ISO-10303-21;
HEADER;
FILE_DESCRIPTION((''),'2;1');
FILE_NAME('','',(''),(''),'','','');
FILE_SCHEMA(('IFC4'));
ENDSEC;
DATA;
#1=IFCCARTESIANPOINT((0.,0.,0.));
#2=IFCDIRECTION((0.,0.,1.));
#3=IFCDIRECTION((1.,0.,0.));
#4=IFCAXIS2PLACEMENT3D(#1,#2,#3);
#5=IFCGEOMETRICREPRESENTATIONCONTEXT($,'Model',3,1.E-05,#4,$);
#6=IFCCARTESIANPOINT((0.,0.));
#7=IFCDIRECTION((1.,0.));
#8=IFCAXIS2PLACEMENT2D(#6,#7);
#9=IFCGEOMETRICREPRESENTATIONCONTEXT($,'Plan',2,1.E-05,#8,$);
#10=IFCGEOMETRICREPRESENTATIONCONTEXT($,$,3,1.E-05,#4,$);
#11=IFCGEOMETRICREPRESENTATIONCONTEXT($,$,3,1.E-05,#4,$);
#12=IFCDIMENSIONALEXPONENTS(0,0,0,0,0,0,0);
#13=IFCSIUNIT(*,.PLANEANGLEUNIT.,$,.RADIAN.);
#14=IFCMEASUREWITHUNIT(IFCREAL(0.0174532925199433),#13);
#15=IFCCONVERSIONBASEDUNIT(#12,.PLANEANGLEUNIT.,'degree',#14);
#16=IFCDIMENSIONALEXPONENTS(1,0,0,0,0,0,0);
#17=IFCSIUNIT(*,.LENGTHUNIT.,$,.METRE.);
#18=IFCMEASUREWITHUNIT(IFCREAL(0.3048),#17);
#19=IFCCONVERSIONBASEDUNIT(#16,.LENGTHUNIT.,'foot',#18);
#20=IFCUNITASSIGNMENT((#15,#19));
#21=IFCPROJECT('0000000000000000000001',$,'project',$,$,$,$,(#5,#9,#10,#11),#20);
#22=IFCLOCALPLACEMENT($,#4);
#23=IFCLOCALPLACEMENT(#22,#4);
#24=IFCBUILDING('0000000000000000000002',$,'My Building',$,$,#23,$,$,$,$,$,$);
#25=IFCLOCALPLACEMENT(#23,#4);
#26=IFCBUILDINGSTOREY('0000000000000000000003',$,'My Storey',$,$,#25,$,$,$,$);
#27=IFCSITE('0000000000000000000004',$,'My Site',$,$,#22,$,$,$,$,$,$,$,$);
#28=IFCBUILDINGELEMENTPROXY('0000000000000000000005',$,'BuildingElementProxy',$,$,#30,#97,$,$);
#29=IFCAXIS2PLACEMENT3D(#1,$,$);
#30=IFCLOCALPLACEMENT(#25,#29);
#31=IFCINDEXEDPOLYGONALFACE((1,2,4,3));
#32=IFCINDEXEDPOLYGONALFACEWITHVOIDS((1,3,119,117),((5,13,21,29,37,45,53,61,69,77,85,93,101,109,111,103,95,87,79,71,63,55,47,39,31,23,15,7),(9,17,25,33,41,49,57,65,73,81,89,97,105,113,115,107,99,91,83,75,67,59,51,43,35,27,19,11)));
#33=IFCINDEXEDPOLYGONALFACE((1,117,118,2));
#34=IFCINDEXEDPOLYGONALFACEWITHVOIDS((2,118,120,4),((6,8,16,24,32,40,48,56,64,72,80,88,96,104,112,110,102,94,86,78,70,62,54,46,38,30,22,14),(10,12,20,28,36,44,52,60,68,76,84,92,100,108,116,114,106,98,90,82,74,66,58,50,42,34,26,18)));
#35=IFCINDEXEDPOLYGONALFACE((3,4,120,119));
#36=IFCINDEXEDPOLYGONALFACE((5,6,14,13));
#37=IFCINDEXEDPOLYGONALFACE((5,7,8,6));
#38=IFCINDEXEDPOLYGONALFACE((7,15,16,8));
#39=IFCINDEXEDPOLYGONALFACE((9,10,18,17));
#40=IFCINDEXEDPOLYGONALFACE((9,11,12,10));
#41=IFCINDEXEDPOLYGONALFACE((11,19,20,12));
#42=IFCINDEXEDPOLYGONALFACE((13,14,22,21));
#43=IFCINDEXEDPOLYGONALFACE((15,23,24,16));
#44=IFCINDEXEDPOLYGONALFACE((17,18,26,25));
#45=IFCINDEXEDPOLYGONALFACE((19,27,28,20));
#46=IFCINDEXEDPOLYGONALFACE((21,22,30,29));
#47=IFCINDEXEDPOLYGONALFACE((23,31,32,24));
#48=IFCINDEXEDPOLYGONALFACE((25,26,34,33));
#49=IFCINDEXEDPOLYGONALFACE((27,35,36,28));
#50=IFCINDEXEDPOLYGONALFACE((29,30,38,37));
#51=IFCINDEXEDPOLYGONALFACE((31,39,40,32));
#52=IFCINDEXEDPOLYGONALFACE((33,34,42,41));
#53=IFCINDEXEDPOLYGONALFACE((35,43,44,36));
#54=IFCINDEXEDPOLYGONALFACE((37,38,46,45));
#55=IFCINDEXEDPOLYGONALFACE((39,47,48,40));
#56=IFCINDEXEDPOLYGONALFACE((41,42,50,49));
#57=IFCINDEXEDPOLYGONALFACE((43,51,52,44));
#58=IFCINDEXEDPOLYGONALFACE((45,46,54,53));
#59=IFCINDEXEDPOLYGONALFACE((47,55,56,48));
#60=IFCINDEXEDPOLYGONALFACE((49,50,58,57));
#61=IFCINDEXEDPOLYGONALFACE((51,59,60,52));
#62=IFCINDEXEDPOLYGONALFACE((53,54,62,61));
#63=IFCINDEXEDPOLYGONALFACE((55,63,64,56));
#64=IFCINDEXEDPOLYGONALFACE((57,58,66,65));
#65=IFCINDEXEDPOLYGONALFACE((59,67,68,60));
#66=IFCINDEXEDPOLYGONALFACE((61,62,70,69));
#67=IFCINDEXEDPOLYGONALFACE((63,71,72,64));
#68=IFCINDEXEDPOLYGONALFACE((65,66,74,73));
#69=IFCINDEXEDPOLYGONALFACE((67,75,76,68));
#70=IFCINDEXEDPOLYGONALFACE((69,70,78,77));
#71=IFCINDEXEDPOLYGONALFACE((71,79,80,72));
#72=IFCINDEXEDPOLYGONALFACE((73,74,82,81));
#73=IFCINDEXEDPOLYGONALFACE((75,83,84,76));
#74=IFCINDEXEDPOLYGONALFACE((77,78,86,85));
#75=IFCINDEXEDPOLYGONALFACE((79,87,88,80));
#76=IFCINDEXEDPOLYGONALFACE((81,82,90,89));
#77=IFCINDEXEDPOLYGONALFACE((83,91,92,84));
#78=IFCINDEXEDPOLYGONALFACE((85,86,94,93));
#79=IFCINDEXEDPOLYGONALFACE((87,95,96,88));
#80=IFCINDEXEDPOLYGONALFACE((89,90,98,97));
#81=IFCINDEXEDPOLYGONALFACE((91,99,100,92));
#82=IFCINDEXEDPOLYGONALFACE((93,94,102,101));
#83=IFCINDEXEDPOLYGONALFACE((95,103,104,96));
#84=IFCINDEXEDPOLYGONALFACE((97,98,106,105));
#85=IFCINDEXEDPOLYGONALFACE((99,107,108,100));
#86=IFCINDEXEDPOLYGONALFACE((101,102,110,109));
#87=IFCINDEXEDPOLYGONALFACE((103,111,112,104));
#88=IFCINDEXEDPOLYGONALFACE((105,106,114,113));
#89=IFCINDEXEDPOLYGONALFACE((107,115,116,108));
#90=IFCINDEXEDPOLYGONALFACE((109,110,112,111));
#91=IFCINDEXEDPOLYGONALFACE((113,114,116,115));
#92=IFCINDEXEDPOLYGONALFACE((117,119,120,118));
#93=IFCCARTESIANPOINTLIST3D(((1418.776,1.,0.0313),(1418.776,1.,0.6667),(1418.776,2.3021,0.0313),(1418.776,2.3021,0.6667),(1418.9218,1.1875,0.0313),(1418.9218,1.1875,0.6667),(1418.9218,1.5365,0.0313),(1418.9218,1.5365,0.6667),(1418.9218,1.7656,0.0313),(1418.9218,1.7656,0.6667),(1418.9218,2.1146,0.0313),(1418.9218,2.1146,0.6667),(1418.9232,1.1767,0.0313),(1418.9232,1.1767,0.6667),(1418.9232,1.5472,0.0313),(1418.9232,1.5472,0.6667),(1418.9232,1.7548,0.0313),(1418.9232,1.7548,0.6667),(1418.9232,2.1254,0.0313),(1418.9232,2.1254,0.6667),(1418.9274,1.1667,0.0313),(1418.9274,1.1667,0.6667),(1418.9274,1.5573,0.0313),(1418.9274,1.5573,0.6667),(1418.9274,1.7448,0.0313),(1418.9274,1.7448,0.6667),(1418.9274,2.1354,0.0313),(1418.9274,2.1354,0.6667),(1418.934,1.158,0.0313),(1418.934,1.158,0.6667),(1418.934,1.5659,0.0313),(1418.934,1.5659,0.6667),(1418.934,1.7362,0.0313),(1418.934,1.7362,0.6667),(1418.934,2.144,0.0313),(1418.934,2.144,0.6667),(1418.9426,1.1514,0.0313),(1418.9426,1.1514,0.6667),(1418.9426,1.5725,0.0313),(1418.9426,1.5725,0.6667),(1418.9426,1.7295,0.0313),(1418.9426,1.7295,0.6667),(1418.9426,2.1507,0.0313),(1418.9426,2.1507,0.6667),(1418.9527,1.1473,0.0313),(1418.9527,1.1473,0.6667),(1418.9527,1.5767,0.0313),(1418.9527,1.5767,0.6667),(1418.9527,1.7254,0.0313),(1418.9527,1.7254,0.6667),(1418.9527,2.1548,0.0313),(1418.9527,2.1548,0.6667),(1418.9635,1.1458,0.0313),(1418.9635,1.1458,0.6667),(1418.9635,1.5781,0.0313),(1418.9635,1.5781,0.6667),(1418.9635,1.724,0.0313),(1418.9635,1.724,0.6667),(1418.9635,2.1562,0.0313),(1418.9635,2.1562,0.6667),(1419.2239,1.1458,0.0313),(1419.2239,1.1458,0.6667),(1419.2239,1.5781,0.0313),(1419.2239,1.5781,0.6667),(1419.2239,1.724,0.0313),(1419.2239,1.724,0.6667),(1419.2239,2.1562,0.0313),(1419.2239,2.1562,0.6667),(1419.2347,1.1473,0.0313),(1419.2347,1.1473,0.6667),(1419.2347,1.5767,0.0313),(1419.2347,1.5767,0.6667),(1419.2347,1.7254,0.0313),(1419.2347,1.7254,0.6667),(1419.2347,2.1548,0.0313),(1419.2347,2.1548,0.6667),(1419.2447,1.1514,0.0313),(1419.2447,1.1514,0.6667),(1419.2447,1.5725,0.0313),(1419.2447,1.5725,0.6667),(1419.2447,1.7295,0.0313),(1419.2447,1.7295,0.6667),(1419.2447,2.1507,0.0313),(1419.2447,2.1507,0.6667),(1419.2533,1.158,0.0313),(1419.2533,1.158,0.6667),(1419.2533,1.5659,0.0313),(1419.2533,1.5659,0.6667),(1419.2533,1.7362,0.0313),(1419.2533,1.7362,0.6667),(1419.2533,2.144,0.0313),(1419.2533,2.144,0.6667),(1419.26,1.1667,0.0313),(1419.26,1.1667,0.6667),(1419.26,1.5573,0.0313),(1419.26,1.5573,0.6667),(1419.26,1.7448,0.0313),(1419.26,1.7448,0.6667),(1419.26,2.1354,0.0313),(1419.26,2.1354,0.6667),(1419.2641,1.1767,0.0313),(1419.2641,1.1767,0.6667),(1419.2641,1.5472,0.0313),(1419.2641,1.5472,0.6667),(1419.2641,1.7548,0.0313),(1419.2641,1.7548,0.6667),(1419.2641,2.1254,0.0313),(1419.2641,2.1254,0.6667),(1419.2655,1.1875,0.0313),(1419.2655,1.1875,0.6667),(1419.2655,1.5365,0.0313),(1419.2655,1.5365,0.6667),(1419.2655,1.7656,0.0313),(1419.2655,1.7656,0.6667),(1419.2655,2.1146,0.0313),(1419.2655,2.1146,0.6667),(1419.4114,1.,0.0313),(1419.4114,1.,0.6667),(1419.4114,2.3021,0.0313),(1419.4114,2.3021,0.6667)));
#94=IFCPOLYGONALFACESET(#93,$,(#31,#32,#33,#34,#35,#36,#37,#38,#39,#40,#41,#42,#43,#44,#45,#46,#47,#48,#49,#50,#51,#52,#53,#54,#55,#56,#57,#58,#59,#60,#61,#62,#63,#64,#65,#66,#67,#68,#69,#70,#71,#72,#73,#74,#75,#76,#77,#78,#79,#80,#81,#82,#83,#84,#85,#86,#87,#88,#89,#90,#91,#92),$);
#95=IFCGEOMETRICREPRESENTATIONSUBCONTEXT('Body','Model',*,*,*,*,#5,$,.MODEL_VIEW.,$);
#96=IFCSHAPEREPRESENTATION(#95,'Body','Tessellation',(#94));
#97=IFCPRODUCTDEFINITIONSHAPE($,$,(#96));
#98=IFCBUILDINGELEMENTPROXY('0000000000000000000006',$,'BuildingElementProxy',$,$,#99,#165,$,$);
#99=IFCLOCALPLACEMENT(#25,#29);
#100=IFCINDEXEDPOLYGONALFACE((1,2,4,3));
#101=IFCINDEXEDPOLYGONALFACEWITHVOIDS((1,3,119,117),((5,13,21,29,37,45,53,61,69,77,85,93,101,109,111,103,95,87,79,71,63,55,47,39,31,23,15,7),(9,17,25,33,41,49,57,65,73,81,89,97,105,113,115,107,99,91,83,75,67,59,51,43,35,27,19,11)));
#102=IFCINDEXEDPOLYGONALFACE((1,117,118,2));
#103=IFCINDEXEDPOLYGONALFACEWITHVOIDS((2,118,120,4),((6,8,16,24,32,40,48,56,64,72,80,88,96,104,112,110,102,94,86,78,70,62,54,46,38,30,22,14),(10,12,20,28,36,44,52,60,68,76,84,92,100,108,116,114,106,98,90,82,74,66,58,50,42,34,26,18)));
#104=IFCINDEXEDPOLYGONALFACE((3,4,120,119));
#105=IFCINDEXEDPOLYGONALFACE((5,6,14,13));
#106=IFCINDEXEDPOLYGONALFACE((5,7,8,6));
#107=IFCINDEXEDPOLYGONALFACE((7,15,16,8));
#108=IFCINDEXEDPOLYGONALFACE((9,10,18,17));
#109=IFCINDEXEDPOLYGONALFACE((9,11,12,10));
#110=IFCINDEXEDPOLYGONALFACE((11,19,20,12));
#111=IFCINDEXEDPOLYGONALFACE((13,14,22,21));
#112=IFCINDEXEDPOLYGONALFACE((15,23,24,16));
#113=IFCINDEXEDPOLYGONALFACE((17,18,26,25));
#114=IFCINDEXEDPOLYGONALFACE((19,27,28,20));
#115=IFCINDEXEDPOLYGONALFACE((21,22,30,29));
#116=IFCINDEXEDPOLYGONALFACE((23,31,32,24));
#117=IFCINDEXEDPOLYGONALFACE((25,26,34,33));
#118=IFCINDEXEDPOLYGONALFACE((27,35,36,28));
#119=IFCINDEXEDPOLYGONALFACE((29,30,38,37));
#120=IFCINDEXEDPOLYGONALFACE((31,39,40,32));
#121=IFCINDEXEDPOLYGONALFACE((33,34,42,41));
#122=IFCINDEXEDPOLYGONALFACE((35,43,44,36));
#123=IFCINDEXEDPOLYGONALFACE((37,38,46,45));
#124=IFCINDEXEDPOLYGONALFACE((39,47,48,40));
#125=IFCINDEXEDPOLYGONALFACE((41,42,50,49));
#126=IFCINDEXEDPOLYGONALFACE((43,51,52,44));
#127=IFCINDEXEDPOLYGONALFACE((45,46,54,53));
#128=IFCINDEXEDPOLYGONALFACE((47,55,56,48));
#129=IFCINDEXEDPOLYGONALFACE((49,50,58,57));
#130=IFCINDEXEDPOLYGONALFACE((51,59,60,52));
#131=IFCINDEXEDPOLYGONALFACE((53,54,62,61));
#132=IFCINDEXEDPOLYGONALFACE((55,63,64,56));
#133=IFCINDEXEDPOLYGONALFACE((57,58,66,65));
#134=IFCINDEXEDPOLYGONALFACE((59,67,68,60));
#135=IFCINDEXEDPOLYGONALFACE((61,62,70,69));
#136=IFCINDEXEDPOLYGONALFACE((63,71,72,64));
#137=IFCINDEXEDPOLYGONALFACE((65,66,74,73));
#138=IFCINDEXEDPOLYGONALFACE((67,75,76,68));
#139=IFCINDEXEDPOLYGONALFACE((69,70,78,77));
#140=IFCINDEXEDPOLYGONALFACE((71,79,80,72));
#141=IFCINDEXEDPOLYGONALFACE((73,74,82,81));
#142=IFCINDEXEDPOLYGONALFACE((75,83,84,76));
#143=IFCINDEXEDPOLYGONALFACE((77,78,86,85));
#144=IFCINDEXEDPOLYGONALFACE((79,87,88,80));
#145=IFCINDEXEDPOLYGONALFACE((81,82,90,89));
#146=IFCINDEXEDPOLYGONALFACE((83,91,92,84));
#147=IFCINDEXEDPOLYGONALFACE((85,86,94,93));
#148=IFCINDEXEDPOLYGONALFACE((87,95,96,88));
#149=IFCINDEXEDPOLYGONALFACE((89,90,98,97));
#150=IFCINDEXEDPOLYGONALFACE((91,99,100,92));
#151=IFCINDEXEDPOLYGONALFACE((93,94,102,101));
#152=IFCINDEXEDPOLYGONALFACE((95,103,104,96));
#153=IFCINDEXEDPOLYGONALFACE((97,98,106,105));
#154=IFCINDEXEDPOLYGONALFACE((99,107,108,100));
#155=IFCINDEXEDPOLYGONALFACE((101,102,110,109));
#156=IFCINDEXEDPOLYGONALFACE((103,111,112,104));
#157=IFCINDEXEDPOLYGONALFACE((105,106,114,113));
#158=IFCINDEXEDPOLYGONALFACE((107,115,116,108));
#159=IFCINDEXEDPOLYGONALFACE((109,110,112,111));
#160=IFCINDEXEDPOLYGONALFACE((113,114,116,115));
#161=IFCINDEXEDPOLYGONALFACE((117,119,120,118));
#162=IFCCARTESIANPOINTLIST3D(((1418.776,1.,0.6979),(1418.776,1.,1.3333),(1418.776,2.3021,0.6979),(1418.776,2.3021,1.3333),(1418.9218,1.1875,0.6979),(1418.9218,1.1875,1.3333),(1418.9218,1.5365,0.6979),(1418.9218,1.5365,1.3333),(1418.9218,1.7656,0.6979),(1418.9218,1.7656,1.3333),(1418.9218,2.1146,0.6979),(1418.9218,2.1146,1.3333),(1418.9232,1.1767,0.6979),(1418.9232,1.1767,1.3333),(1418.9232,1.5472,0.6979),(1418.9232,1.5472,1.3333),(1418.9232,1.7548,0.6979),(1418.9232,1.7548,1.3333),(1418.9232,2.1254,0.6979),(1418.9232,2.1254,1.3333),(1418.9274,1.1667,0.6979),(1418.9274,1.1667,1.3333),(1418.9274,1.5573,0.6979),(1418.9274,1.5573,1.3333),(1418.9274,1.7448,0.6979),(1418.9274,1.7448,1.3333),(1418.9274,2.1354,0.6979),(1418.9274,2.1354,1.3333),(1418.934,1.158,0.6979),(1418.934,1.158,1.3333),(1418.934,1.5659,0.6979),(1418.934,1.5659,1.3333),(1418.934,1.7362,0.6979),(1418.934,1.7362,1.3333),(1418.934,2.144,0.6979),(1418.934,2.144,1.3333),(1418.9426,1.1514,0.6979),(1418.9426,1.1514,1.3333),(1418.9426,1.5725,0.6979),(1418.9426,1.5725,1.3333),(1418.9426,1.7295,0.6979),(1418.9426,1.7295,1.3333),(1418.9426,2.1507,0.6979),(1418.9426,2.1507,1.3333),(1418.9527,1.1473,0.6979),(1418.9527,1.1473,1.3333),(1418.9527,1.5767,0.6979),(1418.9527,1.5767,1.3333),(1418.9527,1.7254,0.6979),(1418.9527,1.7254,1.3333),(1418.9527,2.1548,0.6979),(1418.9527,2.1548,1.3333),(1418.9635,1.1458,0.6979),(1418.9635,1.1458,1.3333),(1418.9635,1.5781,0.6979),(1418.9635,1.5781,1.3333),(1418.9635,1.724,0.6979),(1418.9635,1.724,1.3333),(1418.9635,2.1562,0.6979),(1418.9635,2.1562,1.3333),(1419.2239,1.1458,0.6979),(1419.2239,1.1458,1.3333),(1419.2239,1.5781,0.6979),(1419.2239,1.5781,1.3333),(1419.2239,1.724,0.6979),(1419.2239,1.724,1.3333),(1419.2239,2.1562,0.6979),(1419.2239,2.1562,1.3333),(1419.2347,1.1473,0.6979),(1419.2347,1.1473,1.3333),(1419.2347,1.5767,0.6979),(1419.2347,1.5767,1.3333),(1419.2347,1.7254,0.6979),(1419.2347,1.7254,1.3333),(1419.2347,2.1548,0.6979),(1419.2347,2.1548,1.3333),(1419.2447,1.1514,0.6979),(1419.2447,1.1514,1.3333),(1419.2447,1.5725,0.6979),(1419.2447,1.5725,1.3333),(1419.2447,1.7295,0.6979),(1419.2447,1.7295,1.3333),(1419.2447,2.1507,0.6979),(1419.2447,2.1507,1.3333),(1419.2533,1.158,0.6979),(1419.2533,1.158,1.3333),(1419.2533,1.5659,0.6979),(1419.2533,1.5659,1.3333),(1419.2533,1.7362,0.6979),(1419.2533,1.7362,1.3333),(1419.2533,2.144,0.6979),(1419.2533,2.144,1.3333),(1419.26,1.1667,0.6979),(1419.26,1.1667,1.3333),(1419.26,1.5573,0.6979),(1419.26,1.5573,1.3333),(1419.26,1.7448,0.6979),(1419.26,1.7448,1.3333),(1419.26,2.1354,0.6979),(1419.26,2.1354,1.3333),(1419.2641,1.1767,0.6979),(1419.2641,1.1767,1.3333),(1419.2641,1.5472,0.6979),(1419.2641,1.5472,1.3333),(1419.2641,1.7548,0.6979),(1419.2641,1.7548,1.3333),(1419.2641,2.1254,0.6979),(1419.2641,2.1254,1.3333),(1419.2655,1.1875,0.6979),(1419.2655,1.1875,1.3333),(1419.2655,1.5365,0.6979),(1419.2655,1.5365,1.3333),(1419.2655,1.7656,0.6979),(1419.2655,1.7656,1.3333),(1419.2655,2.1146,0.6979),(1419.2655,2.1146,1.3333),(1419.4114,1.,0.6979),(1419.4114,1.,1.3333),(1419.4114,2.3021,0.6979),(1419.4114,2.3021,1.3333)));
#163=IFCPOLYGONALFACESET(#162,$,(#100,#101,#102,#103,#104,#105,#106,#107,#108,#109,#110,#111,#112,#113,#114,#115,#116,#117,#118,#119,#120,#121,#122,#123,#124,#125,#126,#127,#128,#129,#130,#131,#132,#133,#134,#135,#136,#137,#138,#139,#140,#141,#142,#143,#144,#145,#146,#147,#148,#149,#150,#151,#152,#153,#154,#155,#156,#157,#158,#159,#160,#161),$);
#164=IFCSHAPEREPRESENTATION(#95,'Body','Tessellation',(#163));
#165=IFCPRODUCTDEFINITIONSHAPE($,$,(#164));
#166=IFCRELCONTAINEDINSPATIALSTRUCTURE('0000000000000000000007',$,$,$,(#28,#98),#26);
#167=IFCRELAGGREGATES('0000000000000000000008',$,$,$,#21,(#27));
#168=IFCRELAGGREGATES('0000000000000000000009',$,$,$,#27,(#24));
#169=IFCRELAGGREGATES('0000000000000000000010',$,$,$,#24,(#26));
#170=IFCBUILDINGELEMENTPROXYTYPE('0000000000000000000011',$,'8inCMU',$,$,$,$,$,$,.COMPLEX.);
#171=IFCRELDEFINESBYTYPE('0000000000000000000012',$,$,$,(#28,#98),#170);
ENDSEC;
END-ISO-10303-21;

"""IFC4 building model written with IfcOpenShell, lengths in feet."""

from ifc_helpers import new_model, entity, si_unit, converted_unit, frame, origin_with_axes, origin_2d_with_axis, place, context, subcontext, project, spatial, line, indexed_curve, outline, extrude, source, transform, mapped, type_object, type_shapes, element, save


model = new_model("IFC4")

# Units and contexts
model_context_1 = context("Model", 3, precision=1e-05, world=origin_with_axes())
plan_context = context("Plan", 2, precision=1e-05, world=origin_2d_with_axis())
context_of_model_1 = context(None, 3, precision=1e-05, world=origin_with_axes())
context_of_model_2 = context(None, 3, precision=1e-05, world=origin_with_axes())
body_context_1 = subcontext(model_context_1, "Body", "Model", "MODEL_VIEW")
ifc_project = project(units=[converted_unit("PLANEANGLEUNIT", "degree", entity("IfcReal", 0.0174532925199433), si_unit("PLANEANGLEUNIT", "RADIAN"), dimensions=[0, 0, 0, 0, 0, 0, 0]), converted_unit("LENGTHUNIT", "foot", entity("IfcReal", 0.3048), si_unit("LENGTHUNIT", "METRE"), dimensions=[1, 0, 0, 0, 0, 0, 0])], contexts=[model_context_1, plan_context, context_of_model_1, context_of_model_2])

# Site, building, storey
site_placement = place(None, origin_with_axes())
site = spatial("IfcSite", under=ifc_project, at=site_placement, Name="My Site")
building_placement = place(site_placement, origin_with_axes())
building = spatial("IfcBuilding", under=site, at=building_placement, Name="My Building")
storey_placement = place(building_placement, origin_with_axes())
storey = spatial("IfcBuildingStorey", under=building, at=storey_placement, Name="My Storey")

# Building element proxies
building_element_proxy_type_1 = type_object("IfcBuildingElementProxyType", Name="8inCMU", PredefinedType="COMPLEX")
shared_shape_1 = source(origin_with_axes(), body_context_1, "Body", "SweptSolid", [
    extrude(outline(indexed_curve([(-0.3177, -0.651), (0.3177, -0.651), (0.3177, 0.651), (-0.3177, 0.651), (0.1719, -0.1146), (0.1719, -0.4635), (0.1705, -0.4743), (0.1663, -0.4844), (0.1597, -0.493), (0.151, -0.4996), (0.141, -0.5038), (0.1302, -0.5052), (-0.1302, -0.5052), (-0.141, -0.5038), (-0.151, -0.4996), (-0.1597, -0.493), (-0.1663, -0.4844), (-0.1705, -0.4743), (-0.1719, -0.4635), (-0.1719, -0.1146), (-0.1705, -0.1038), (-0.1663, -0.0938), (-0.1597, -0.0851), (-0.151, -0.0785), (-0.141, -0.0743), (-0.1302, -0.0729), (0.1302, -0.0729), (0.141, -0.0743), (0.151, -0.0785), (0.1597, -0.0851), (0.1663, -0.0938), (0.1705, -0.1038), (0.151, 0.0785), (0.141, 0.0743), (0.1302, 0.0729), (-0.1302, 0.0729), (-0.141, 0.0743), (-0.151, 0.0785), (-0.1597, 0.0851), (-0.1663, 0.0937), (-0.1705, 0.1038), (-0.1719, 0.1146), (-0.1719, 0.4635), (-0.1705, 0.4743), (-0.1663, 0.4844), (-0.1597, 0.493), (-0.151, 0.4996), (-0.141, 0.5038), (-0.1302, 0.5052), (0.1302, 0.5052), (0.141, 0.5038), (0.151, 0.4996), (0.1597, 0.493), (0.1663, 0.4844), (0.1705, 0.4743), (0.1719, 0.4635), (0.1719, 0.1146), (0.1705, 0.1038), (0.1663, 0.0937), (0.1597, 0.0851)], segments=[line(4, 3), line(3, 2), line(2, 1), line(1, 4)], self_intersect=False), holes=[indexed_curve([(-0.3177, -0.651), (0.3177, -0.651), (0.3177, 0.651), (-0.3177, 0.651), (0.1719, -0.1146), (0.1719, -0.4635), (0.1705, -0.4743), (0.1663, -0.4844), (0.1597, -0.493), (0.151, -0.4996), (0.141, -0.5038), (0.1302, -0.5052), (-0.1302, -0.5052), (-0.141, -0.5038), (-0.151, -0.4996), (-0.1597, -0.493), (-0.1663, -0.4844), (-0.1705, -0.4743), (-0.1719, -0.4635), (-0.1719, -0.1146), (-0.1705, -0.1038), (-0.1663, -0.0938), (-0.1597, -0.0851), (-0.151, -0.0785), (-0.141, -0.0743), (-0.1302, -0.0729), (0.1302, -0.0729), (0.141, -0.0743), (0.151, -0.0785), (0.1597, -0.0851), (0.1663, -0.0938), (0.1705, -0.1038), (0.151, 0.0785), (0.141, 0.0743), (0.1302, 0.0729), (-0.1302, 0.0729), (-0.141, 0.0743), (-0.151, 0.0785), (-0.1597, 0.0851), (-0.1663, 0.0937), (-0.1705, 0.1038), (-0.1719, 0.1146), (-0.1719, 0.4635), (-0.1705, 0.4743), (-0.1663, 0.4844), (-0.1597, 0.493), (-0.151, 0.4996), (-0.141, 0.5038), (-0.1302, 0.5052), (0.1302, 0.5052), (0.141, 0.5038), (0.151, 0.4996), (0.1597, 0.493), (0.1663, 0.4844), (0.1705, 0.4743), (0.1719, 0.4635), (0.1719, 0.1146), (0.1705, 0.1038), (0.1663, 0.0937), (0.1597, 0.0851)], segments=[line(20, 19), line(19, 18), line(18, 17), line(17, 16), line(16, 15), line(15, 14), line(14, 13), line(13, 12), line(12, 11), line(11, 10), line(10, 9), line(9, 8), line(8, 7), line(7, 6), line(6, 5), line(5, 32), line(32, 31), line(31, 30), line(30, 29), line(29, 28), line(28, 27), line(27, 26), line(26, 25), line(25, 24), line(24, 23), line(23, 22), line(22, 21), line(21, 20)], self_intersect=False), indexed_curve([(-0.3177, -0.651), (0.3177, -0.651), (0.3177, 0.651), (-0.3177, 0.651), (0.1719, -0.1146), (0.1719, -0.4635), (0.1705, -0.4743), (0.1663, -0.4844), (0.1597, -0.493), (0.151, -0.4996), (0.141, -0.5038), (0.1302, -0.5052), (-0.1302, -0.5052), (-0.141, -0.5038), (-0.151, -0.4996), (-0.1597, -0.493), (-0.1663, -0.4844), (-0.1705, -0.4743), (-0.1719, -0.4635), (-0.1719, -0.1146), (-0.1705, -0.1038), (-0.1663, -0.0938), (-0.1597, -0.0851), (-0.151, -0.0785), (-0.141, -0.0743), (-0.1302, -0.0729), (0.1302, -0.0729), (0.141, -0.0743), (0.151, -0.0785), (0.1597, -0.0851), (0.1663, -0.0938), (0.1705, -0.1038), (0.151, 0.0785), (0.141, 0.0743), (0.1302, 0.0729), (-0.1302, 0.0729), (-0.141, 0.0743), (-0.151, 0.0785), (-0.1597, 0.0851), (-0.1663, 0.0937), (-0.1705, 0.1038), (-0.1719, 0.1146), (-0.1719, 0.4635), (-0.1705, 0.4743), (-0.1663, 0.4844), (-0.1597, 0.493), (-0.151, 0.4996), (-0.141, 0.5038), (-0.1302, 0.5052), (0.1302, 0.5052), (0.141, 0.5038), (0.151, 0.4996), (0.1597, 0.493), (0.1663, 0.4844), (0.1705, 0.4743), (0.1719, 0.4635), (0.1719, 0.1146), (0.1705, 0.1038), (0.1663, 0.0937), (0.1597, 0.0851)], segments=[line(44, 43), line(43, 42), line(42, 41), line(41, 40), line(40, 39), line(39, 38), line(38, 37), line(37, 36), line(36, 35), line(35, 34), line(34, 33), line(33, 60), line(60, 59), line(59, 58), line(58, 57), line(57, 56), line(56, 55), line(55, 54), line(54, 53), line(53, 52), line(52, 51), line(51, 50), line(50, 49), line(49, 48), line(48, 47), line(47, 46), line(46, 45), line(45, 44)], self_intersect=False)]), frame((-0.651, 0.0, 0.0), z_axis=(0.0, 0.0, 1.0), x_axis=(0.0, -1.0, 0.0)), (0.0, 0.0, 1.0), 0.6354),
])
type_shapes(building_element_proxy_type_1, [shared_shape_1])
for number, where, z_axis, x_axis, name in (
    (1, (1419.0936, 2.3021, 0.0313), (0.0, 0.0, 1.0), (0.0, 1.0, 0.0), "BuildingElementProxy"),
    (2, (1419.0936, 2.3021, 0.6979), (0.0, 0.0, 1.0), (0.0, 1.0, 0.0), "BuildingElementProxy"),
):
    element("IfcBuildingElementProxy", number, at=place(storey_placement, frame(where, z_axis=z_axis, x_axis=x_axis)), inside=storey, type_object=building_element_proxy_type_1, Name=name, context=body_context_1, shape_type="MappedRepresentation", body=[
        mapped(shared_shape_1, transform((0.0, 0.0, 0.0), x_axis=(1.0, 0.0, 0.0), y_axis=(0.0, 1.0, 0.0), z_axis=(0.0, 0.0, 1.0), scale=1.0)),
    ])

save(model, "model.ifc")
